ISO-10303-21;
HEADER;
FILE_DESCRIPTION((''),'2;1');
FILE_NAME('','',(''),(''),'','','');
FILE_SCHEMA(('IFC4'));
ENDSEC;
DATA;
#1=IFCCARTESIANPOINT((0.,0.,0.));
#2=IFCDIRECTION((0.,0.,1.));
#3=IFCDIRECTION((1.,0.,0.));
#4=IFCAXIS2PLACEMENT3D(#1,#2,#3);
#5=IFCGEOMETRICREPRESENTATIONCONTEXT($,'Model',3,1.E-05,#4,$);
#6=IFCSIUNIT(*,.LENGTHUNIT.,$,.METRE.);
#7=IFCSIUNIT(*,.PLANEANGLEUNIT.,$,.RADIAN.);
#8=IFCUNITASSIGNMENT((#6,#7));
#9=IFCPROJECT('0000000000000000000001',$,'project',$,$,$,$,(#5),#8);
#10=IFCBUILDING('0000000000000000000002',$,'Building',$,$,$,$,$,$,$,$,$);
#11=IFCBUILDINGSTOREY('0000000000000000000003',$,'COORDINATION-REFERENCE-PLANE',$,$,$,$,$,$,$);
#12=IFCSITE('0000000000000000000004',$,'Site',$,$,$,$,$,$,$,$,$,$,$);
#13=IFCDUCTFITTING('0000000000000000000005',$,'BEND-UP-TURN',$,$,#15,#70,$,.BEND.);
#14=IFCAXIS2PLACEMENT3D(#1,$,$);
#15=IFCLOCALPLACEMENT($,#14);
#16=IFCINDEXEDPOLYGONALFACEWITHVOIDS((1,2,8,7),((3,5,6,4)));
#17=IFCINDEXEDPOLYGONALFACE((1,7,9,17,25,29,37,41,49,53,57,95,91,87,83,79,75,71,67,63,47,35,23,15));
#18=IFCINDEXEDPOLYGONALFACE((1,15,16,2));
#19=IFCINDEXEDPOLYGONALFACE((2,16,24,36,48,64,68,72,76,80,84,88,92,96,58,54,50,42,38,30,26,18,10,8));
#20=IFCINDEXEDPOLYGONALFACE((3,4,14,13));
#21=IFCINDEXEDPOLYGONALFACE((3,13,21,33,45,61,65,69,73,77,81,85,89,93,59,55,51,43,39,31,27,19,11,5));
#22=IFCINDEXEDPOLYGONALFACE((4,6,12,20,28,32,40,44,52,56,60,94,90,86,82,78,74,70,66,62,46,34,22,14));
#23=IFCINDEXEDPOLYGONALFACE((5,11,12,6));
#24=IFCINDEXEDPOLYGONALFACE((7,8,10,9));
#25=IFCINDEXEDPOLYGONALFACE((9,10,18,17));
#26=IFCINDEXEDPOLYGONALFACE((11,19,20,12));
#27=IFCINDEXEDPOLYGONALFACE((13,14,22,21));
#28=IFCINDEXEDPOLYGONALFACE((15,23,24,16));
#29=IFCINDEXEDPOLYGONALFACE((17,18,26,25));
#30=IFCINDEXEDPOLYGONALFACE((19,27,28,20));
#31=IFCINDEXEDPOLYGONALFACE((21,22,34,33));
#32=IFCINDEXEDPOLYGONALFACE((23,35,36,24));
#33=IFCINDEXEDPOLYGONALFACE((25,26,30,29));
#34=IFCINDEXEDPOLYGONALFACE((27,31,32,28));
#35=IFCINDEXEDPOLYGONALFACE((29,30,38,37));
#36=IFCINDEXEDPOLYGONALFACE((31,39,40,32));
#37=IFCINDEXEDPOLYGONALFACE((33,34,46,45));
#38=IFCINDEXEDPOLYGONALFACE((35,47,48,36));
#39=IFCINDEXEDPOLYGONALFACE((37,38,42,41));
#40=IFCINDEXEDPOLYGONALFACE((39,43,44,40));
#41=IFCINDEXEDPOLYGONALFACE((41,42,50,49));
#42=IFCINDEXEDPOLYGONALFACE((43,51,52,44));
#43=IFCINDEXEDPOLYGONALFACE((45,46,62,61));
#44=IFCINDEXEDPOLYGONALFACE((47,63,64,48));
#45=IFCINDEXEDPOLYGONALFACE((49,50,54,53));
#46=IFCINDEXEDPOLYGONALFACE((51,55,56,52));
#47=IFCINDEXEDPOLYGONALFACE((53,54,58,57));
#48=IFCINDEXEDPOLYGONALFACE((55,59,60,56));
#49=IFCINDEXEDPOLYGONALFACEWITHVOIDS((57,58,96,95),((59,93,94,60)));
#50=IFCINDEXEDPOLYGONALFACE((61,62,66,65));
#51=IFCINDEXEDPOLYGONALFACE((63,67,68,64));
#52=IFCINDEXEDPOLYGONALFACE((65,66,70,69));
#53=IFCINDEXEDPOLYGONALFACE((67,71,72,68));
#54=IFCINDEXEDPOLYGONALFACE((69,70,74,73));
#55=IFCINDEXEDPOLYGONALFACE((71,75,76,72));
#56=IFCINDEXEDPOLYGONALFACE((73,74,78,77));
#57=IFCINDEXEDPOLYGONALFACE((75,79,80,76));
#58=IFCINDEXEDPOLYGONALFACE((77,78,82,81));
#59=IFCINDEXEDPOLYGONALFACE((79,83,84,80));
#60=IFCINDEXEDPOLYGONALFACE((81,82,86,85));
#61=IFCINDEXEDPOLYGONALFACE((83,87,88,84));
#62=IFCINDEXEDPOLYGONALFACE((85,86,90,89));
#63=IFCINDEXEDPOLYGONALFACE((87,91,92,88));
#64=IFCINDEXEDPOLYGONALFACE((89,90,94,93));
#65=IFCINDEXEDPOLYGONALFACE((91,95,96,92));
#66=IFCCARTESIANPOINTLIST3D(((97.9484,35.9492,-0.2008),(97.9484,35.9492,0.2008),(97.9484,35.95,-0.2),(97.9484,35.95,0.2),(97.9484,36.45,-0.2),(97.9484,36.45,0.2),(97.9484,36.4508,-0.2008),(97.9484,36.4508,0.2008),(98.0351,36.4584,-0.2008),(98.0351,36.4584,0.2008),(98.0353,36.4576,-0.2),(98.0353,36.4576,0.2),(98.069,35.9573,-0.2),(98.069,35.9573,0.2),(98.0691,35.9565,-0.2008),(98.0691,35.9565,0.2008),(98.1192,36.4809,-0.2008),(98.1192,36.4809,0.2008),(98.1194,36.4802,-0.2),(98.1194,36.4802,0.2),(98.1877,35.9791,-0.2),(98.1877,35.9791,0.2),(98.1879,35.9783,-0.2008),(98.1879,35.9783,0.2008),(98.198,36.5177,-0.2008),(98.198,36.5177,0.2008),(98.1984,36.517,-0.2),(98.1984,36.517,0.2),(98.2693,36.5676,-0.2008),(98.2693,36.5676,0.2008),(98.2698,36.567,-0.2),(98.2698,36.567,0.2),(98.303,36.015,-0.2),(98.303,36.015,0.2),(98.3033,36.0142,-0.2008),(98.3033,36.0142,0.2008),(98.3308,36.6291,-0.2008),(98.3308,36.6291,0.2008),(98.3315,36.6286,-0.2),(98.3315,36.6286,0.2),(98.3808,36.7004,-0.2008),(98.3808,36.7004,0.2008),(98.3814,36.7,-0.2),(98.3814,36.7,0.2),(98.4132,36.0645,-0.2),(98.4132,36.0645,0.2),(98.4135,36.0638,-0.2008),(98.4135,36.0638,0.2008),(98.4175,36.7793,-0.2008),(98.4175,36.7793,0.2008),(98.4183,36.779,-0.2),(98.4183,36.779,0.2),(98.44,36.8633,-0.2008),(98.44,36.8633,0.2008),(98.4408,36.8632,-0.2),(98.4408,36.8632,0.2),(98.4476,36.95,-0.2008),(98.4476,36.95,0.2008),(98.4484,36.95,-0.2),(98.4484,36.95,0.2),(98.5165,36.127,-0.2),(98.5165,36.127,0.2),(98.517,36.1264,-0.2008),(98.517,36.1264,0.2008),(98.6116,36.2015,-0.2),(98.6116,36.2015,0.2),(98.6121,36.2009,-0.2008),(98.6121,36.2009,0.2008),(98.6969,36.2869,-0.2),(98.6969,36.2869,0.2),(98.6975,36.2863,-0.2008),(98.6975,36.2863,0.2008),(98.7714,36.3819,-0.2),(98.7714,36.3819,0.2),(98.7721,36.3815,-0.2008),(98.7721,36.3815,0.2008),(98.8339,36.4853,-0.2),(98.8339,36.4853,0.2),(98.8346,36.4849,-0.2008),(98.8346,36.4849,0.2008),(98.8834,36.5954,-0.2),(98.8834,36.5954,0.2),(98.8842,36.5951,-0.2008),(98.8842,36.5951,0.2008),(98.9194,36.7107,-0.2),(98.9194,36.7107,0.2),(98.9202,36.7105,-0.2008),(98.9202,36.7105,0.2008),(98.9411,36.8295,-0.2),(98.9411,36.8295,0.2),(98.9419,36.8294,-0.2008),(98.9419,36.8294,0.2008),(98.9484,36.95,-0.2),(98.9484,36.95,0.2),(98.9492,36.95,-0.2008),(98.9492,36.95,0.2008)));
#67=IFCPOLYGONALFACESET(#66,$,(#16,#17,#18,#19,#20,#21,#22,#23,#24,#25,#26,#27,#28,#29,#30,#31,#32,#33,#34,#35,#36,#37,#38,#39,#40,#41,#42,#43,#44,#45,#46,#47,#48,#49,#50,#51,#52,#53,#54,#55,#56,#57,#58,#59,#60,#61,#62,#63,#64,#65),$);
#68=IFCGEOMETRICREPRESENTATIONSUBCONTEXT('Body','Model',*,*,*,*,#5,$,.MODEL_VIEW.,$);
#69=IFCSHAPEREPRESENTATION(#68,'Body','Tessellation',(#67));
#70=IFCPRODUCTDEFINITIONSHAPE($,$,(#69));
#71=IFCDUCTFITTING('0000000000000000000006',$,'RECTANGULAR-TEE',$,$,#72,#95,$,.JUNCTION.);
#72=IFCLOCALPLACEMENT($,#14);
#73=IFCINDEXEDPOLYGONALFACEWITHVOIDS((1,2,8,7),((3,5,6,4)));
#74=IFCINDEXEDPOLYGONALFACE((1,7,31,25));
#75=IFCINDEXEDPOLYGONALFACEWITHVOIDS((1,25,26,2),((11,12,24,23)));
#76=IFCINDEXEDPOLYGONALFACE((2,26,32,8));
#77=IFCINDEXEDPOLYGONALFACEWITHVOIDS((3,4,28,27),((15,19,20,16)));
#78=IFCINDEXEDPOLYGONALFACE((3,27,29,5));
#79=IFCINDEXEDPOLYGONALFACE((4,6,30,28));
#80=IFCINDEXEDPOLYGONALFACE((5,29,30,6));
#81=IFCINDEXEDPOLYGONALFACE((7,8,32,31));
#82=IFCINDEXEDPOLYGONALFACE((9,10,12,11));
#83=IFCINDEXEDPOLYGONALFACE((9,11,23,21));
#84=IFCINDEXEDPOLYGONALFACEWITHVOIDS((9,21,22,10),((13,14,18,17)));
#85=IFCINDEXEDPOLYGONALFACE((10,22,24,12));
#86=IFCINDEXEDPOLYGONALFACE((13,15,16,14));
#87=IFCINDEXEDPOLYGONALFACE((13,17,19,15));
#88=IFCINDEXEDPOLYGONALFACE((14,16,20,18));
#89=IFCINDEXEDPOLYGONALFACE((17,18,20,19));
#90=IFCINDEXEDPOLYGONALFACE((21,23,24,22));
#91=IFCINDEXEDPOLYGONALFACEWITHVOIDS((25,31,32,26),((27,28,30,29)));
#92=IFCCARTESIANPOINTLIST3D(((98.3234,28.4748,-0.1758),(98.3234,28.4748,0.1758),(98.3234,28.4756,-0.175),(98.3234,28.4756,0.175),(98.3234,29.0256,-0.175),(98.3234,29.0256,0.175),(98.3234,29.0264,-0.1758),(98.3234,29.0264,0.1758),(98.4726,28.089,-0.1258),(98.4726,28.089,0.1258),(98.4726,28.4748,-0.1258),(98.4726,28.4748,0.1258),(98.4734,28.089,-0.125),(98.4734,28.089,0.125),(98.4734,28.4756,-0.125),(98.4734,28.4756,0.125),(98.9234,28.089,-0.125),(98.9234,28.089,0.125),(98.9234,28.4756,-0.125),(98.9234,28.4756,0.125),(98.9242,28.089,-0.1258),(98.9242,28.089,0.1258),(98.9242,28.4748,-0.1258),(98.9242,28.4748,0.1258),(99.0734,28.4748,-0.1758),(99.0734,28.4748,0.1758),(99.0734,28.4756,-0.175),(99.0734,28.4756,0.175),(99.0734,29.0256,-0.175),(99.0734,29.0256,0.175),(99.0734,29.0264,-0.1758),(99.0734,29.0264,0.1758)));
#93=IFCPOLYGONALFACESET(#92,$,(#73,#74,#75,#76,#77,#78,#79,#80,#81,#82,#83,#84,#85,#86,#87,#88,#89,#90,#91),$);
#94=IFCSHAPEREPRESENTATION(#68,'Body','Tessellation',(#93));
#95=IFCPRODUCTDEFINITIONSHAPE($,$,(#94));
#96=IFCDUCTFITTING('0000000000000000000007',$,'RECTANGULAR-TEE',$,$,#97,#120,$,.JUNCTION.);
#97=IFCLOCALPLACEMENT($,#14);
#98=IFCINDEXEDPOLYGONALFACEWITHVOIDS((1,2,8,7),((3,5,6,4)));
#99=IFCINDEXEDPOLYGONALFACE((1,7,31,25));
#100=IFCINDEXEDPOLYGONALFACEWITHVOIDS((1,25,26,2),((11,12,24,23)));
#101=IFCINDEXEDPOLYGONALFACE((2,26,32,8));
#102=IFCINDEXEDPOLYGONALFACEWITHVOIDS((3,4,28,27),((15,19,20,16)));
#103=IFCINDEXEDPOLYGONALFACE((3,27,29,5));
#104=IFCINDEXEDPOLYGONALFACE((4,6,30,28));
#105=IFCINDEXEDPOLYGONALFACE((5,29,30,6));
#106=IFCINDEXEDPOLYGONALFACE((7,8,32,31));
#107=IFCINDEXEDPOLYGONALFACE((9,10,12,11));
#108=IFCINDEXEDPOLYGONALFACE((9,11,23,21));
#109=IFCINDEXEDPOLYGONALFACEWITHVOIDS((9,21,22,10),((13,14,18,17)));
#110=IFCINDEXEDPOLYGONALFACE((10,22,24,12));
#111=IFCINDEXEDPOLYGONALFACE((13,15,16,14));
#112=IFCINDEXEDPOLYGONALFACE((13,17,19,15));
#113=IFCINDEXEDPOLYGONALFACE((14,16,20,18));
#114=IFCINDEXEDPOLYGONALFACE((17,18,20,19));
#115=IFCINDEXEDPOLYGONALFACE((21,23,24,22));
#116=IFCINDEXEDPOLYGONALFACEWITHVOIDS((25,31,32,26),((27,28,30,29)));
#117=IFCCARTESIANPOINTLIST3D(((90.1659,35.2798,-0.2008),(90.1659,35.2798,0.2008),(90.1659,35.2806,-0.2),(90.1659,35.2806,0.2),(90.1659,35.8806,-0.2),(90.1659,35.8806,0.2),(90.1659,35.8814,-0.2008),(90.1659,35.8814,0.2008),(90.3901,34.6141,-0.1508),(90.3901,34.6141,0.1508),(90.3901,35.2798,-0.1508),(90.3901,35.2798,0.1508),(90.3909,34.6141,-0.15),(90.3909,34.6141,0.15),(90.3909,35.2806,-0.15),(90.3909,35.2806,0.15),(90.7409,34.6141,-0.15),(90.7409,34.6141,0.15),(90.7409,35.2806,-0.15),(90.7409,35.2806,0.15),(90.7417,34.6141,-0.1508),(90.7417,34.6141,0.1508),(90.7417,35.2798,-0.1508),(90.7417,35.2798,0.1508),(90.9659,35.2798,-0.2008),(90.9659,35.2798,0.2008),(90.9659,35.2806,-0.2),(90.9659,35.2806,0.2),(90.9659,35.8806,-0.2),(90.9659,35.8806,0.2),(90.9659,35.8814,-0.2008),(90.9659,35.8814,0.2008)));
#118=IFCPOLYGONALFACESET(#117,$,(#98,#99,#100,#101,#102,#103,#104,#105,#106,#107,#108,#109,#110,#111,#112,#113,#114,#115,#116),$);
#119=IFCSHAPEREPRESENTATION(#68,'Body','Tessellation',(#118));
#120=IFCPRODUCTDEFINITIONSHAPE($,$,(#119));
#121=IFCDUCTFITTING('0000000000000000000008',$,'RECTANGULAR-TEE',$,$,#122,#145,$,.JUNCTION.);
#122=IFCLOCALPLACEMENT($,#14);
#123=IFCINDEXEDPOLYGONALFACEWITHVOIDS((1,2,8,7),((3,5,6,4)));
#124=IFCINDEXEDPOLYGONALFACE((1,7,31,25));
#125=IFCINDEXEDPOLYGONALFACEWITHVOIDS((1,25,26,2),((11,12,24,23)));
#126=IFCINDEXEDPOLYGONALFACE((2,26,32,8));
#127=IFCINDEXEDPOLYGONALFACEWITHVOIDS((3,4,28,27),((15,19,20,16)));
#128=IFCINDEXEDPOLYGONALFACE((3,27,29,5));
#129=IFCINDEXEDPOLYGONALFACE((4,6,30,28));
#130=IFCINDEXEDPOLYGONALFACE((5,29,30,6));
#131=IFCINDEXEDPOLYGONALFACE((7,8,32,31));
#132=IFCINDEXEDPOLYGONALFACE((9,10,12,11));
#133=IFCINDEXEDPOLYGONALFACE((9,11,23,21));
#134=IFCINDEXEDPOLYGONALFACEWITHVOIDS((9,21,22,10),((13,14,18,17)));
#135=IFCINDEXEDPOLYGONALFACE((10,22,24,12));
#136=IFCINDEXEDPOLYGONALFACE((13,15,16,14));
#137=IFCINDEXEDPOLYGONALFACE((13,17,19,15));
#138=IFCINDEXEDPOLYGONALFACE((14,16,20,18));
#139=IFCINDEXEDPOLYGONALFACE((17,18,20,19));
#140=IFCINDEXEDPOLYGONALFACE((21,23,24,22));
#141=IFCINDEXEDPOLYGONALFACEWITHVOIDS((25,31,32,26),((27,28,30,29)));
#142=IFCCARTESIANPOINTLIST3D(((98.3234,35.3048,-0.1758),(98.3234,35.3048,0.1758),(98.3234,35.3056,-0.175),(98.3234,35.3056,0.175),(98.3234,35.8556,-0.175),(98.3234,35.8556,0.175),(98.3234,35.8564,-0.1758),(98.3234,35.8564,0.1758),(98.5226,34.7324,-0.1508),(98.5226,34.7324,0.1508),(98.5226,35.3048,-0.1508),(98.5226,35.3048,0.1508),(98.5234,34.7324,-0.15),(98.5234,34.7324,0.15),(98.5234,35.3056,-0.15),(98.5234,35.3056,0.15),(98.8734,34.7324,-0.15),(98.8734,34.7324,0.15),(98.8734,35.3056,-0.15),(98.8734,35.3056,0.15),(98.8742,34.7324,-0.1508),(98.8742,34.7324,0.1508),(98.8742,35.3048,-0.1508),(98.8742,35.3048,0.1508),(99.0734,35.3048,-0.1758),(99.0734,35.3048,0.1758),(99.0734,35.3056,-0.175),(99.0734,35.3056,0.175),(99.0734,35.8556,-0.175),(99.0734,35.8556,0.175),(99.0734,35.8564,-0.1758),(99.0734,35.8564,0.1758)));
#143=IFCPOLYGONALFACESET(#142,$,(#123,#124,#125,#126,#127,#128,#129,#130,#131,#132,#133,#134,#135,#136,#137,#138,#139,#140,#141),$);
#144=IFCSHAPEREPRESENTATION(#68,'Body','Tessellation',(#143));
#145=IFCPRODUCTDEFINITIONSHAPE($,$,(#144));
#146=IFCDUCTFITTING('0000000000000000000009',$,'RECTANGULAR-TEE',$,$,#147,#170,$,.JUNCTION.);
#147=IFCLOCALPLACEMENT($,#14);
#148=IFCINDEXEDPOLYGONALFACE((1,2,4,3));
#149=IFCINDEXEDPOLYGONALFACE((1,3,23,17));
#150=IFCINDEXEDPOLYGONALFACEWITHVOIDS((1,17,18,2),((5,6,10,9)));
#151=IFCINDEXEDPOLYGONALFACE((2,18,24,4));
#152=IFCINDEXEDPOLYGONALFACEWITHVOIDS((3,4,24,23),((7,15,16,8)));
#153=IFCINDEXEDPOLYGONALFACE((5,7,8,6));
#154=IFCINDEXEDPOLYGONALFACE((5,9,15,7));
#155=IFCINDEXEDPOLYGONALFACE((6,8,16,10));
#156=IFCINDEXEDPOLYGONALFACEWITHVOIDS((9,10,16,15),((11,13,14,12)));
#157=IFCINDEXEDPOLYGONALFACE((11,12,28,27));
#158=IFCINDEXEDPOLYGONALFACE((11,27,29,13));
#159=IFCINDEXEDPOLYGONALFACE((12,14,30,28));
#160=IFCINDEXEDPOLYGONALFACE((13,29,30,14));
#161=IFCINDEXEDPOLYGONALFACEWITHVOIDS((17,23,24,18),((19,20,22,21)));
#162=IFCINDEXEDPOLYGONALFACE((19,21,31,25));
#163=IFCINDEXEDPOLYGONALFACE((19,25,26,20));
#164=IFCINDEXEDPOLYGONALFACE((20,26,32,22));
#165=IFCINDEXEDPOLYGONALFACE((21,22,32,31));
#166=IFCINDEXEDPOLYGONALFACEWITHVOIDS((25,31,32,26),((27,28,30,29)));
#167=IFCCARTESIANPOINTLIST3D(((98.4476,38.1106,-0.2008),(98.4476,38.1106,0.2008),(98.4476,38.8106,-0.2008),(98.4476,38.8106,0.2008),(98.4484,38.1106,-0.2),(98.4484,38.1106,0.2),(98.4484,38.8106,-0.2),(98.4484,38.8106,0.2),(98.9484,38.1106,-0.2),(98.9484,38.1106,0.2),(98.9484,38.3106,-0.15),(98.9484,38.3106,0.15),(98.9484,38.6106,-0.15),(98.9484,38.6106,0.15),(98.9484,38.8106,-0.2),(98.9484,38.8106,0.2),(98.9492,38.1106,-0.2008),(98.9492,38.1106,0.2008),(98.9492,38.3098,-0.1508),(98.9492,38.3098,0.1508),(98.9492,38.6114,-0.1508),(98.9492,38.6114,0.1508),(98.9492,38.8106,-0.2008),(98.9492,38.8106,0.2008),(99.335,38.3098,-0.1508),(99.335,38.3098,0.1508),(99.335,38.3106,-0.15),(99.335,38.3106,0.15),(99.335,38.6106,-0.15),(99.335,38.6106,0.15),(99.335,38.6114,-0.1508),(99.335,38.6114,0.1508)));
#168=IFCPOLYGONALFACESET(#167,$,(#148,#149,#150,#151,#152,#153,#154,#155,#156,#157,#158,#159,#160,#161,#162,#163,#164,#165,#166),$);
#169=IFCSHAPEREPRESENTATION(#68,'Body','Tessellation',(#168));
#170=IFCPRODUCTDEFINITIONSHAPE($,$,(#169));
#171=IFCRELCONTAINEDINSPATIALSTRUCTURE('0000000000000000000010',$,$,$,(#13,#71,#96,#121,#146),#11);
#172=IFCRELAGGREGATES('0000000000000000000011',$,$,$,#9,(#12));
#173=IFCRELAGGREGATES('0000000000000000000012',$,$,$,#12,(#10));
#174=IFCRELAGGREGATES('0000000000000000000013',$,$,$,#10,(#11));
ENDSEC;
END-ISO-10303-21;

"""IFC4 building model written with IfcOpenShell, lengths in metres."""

from ifc_helpers import new_model, entity, si_unit, frame, origin_with_axes, place, context, subcontext, project, spatial, rectangle, extrude, boolean, element, save


model = new_model("IFC4")

# Units and contexts
model_context = context("Model", 3, precision=1e-05, world=origin_with_axes())
body_context_1 = subcontext(model_context, "Body", "Model", "MODEL_VIEW")
ifc_project = project(units=[si_unit("LENGTHUNIT", "METRE"), si_unit("PLANEANGLEUNIT", "RADIAN")], contexts=[model_context])

# Site, building, storey
site = spatial("IfcSite", under=ifc_project, Name="Site")
building = spatial("IfcBuilding", under=site, Name="Building")
storey = spatial("IfcBuildingStorey", under=building, Name="COORDINATION-REFERENCE-PLANE")

# Duct fittings
duct_fitting_1_placement = place(None, frame((97.9484, 36.95, 0.0), z_axis=(0.0, 0.0, 1.0), x_axis=(0.0, -1.0, 0.0)))
cartesian_point_1 = entity("IfcCartesianPoint", [0.0, 0.0, 0.0])
element("IfcDuctFitting", 1, at=duct_fitting_1_placement, inside=storey, Name="BEND-UP-TURN", PredefinedType="BEND", context=body_context_1, shape_type="SweptSolid", body=[
    entity("IfcRevolvedAreaSolid", entity("IfcRectangleHollowProfileDef", "AREA", None, entity("IfcAxis2Placement2D", entity("IfcCartesianPoint", [0.75, 0.0])), 0.5016, 0.4016, 0.0008), entity("IfcAxis2Placement3D", cartesian_point_1, entity("IfcDirection", [0.0, -1.0, 0.0]), entity("IfcDirection", [1.0, 0.0, 0.0])), entity("IfcAxis1Placement", cartesian_point_1, entity("IfcDirection", [0.0, 1.0, 0.0])), 1.570796),
])
duct_fitting_2_placement = place(None, frame((98.6984, 28.7506, 0.0), z_axis=(1.0, 0.0, 0.0), x_axis=(0.0, -1.0, 0.0)))
solid_1 = boolean("UNION", extrude(rectangle(XDim=0.55, YDim=0.35), frame((0.0, 0.0, -0.375), z_axis=(0.0, 0.0, 1.0), x_axis=(1.0, 0.0, 0.0)), (0.0, 0.0, 1.0), 0.75), extrude(rectangle(XDim=0.45, YDim=0.25), frame((0.0, 0.0, 0.0), z_axis=(1.0, 0.0, 0.0), x_axis=(0.0, 0.0, -1.0)), (0.0, 0.0, 1.0), 0.6616))
element("IfcDuctFitting", 2, at=duct_fitting_2_placement, inside=storey, Name="RECTANGULAR-TEE", PredefinedType="JUNCTION", context=body_context_1, shape_type="CSG", body=[
    boolean("DIFFERENCE", boolean("UNION", extrude(rectangle(XDim=0.5516, YDim=0.3516), frame((0.0, 0.0, -0.375), z_axis=(0.0, 0.0, 1.0), x_axis=(1.0, 0.0, 0.0)), (0.0, 0.0, 1.0), 0.75), extrude(rectangle(XDim=0.4516, YDim=0.2516), frame((0.0, 0.0, 0.0), z_axis=(1.0, 0.0, 0.0), x_axis=(0.0, 0.0, -1.0)), (0.0, 0.0, 1.0), 0.6616)), solid_1),
])
duct_fitting_3_placement = place(None, frame((90.5659, 35.5806, 0.0), z_axis=(1.0, 0.0, 0.0), x_axis=(0.0, -1.0, 0.0)))
solid_2 = boolean("UNION", extrude(rectangle(XDim=0.6, YDim=0.4), frame((0.0, 0.0, -0.4), z_axis=(0.0, 0.0, 1.0), x_axis=(1.0, 0.0, 0.0)), (0.0, 0.0, 1.0), 0.8), extrude(rectangle(XDim=0.35, YDim=0.3), frame((0.0, 0.0, 0.0), z_axis=(1.0, 0.0, 0.0), x_axis=(0.0, 0.0, -1.0)), (0.0, 0.0, 1.0), 0.9665))
element("IfcDuctFitting", 3, at=duct_fitting_3_placement, inside=storey, Name="RECTANGULAR-TEE", PredefinedType="JUNCTION", context=body_context_1, shape_type="CSG", body=[
    boolean("DIFFERENCE", boolean("UNION", extrude(rectangle(XDim=0.6016, YDim=0.4016), frame((0.0, 0.0, -0.4), z_axis=(0.0, 0.0, 1.0), x_axis=(1.0, 0.0, 0.0)), (0.0, 0.0, 1.0), 0.8), extrude(rectangle(XDim=0.3516, YDim=0.3016), frame((0.0, 0.0, 0.0), z_axis=(1.0, 0.0, 0.0), x_axis=(0.0, 0.0, -1.0)), (0.0, 0.0, 1.0), 0.9665)), solid_2),
])
duct_fitting_4_placement = place(None, frame((98.6984, 35.5806, 0.0), z_axis=(1.0, 0.0, 0.0), x_axis=(0.0, -1.0, 0.0)))
solid_3 = boolean("UNION", extrude(rectangle(XDim=0.55, YDim=0.35), frame((0.0, 0.0, -0.375), z_axis=(0.0, 0.0, 1.0), x_axis=(1.0, 0.0, 0.0)), (0.0, 0.0, 1.0), 0.75), extrude(rectangle(XDim=0.35, YDim=0.3), frame((0.0, 0.0, 0.0), z_axis=(1.0, 0.0, 0.0), x_axis=(0.0, 0.0, -1.0)), (0.0, 0.0, 1.0), 0.8482))
element("IfcDuctFitting", 4, at=duct_fitting_4_placement, inside=storey, Name="RECTANGULAR-TEE", PredefinedType="JUNCTION", context=body_context_1, shape_type="CSG", body=[
    boolean("DIFFERENCE", boolean("UNION", extrude(rectangle(XDim=0.5516, YDim=0.3516), frame((0.0, 0.0, -0.375), z_axis=(0.0, 0.0, 1.0), x_axis=(1.0, 0.0, 0.0)), (0.0, 0.0, 1.0), 0.75), extrude(rectangle(XDim=0.3516, YDim=0.3016), frame((0.0, 0.0, 0.0), z_axis=(1.0, 0.0, 0.0), x_axis=(0.0, 0.0, -1.0)), (0.0, 0.0, 1.0), 0.8482)), solid_3),
])
duct_fitting_5_placement = place(None, frame((98.6984, 38.4606, 0.0), z_axis=(0.0, 1.0, 0.0), x_axis=(1.0, 0.0, 0.0)))
solid_4 = boolean("UNION", extrude(rectangle(XDim=0.5, YDim=0.4), frame((0.0, 0.0, -0.35), z_axis=(0.0, 0.0, 1.0), x_axis=(1.0, 0.0, 0.0)), (0.0, 0.0, 1.0), 0.7), extrude(rectangle(XDim=0.3, YDim=0.3), frame((0.0, 0.0, 0.0), z_axis=(1.0, 0.0, 0.0), x_axis=(0.0, 0.0, -1.0)), (0.0, 0.0, 1.0), 0.6366))
element("IfcDuctFitting", 5, at=duct_fitting_5_placement, inside=storey, Name="RECTANGULAR-TEE", PredefinedType="JUNCTION", context=body_context_1, shape_type="CSG", body=[
    boolean("DIFFERENCE", boolean("UNION", extrude(rectangle(XDim=0.5016, YDim=0.4016), frame((0.0, 0.0, -0.35), z_axis=(0.0, 0.0, 1.0), x_axis=(1.0, 0.0, 0.0)), (0.0, 0.0, 1.0), 0.7), extrude(rectangle(XDim=0.3016, YDim=0.3016), frame((0.0, 0.0, 0.0), z_axis=(1.0, 0.0, 0.0), x_axis=(0.0, 0.0, -1.0)), (0.0, 0.0, 1.0), 0.6366)), solid_4),
])

save(model, "model.ifc")
